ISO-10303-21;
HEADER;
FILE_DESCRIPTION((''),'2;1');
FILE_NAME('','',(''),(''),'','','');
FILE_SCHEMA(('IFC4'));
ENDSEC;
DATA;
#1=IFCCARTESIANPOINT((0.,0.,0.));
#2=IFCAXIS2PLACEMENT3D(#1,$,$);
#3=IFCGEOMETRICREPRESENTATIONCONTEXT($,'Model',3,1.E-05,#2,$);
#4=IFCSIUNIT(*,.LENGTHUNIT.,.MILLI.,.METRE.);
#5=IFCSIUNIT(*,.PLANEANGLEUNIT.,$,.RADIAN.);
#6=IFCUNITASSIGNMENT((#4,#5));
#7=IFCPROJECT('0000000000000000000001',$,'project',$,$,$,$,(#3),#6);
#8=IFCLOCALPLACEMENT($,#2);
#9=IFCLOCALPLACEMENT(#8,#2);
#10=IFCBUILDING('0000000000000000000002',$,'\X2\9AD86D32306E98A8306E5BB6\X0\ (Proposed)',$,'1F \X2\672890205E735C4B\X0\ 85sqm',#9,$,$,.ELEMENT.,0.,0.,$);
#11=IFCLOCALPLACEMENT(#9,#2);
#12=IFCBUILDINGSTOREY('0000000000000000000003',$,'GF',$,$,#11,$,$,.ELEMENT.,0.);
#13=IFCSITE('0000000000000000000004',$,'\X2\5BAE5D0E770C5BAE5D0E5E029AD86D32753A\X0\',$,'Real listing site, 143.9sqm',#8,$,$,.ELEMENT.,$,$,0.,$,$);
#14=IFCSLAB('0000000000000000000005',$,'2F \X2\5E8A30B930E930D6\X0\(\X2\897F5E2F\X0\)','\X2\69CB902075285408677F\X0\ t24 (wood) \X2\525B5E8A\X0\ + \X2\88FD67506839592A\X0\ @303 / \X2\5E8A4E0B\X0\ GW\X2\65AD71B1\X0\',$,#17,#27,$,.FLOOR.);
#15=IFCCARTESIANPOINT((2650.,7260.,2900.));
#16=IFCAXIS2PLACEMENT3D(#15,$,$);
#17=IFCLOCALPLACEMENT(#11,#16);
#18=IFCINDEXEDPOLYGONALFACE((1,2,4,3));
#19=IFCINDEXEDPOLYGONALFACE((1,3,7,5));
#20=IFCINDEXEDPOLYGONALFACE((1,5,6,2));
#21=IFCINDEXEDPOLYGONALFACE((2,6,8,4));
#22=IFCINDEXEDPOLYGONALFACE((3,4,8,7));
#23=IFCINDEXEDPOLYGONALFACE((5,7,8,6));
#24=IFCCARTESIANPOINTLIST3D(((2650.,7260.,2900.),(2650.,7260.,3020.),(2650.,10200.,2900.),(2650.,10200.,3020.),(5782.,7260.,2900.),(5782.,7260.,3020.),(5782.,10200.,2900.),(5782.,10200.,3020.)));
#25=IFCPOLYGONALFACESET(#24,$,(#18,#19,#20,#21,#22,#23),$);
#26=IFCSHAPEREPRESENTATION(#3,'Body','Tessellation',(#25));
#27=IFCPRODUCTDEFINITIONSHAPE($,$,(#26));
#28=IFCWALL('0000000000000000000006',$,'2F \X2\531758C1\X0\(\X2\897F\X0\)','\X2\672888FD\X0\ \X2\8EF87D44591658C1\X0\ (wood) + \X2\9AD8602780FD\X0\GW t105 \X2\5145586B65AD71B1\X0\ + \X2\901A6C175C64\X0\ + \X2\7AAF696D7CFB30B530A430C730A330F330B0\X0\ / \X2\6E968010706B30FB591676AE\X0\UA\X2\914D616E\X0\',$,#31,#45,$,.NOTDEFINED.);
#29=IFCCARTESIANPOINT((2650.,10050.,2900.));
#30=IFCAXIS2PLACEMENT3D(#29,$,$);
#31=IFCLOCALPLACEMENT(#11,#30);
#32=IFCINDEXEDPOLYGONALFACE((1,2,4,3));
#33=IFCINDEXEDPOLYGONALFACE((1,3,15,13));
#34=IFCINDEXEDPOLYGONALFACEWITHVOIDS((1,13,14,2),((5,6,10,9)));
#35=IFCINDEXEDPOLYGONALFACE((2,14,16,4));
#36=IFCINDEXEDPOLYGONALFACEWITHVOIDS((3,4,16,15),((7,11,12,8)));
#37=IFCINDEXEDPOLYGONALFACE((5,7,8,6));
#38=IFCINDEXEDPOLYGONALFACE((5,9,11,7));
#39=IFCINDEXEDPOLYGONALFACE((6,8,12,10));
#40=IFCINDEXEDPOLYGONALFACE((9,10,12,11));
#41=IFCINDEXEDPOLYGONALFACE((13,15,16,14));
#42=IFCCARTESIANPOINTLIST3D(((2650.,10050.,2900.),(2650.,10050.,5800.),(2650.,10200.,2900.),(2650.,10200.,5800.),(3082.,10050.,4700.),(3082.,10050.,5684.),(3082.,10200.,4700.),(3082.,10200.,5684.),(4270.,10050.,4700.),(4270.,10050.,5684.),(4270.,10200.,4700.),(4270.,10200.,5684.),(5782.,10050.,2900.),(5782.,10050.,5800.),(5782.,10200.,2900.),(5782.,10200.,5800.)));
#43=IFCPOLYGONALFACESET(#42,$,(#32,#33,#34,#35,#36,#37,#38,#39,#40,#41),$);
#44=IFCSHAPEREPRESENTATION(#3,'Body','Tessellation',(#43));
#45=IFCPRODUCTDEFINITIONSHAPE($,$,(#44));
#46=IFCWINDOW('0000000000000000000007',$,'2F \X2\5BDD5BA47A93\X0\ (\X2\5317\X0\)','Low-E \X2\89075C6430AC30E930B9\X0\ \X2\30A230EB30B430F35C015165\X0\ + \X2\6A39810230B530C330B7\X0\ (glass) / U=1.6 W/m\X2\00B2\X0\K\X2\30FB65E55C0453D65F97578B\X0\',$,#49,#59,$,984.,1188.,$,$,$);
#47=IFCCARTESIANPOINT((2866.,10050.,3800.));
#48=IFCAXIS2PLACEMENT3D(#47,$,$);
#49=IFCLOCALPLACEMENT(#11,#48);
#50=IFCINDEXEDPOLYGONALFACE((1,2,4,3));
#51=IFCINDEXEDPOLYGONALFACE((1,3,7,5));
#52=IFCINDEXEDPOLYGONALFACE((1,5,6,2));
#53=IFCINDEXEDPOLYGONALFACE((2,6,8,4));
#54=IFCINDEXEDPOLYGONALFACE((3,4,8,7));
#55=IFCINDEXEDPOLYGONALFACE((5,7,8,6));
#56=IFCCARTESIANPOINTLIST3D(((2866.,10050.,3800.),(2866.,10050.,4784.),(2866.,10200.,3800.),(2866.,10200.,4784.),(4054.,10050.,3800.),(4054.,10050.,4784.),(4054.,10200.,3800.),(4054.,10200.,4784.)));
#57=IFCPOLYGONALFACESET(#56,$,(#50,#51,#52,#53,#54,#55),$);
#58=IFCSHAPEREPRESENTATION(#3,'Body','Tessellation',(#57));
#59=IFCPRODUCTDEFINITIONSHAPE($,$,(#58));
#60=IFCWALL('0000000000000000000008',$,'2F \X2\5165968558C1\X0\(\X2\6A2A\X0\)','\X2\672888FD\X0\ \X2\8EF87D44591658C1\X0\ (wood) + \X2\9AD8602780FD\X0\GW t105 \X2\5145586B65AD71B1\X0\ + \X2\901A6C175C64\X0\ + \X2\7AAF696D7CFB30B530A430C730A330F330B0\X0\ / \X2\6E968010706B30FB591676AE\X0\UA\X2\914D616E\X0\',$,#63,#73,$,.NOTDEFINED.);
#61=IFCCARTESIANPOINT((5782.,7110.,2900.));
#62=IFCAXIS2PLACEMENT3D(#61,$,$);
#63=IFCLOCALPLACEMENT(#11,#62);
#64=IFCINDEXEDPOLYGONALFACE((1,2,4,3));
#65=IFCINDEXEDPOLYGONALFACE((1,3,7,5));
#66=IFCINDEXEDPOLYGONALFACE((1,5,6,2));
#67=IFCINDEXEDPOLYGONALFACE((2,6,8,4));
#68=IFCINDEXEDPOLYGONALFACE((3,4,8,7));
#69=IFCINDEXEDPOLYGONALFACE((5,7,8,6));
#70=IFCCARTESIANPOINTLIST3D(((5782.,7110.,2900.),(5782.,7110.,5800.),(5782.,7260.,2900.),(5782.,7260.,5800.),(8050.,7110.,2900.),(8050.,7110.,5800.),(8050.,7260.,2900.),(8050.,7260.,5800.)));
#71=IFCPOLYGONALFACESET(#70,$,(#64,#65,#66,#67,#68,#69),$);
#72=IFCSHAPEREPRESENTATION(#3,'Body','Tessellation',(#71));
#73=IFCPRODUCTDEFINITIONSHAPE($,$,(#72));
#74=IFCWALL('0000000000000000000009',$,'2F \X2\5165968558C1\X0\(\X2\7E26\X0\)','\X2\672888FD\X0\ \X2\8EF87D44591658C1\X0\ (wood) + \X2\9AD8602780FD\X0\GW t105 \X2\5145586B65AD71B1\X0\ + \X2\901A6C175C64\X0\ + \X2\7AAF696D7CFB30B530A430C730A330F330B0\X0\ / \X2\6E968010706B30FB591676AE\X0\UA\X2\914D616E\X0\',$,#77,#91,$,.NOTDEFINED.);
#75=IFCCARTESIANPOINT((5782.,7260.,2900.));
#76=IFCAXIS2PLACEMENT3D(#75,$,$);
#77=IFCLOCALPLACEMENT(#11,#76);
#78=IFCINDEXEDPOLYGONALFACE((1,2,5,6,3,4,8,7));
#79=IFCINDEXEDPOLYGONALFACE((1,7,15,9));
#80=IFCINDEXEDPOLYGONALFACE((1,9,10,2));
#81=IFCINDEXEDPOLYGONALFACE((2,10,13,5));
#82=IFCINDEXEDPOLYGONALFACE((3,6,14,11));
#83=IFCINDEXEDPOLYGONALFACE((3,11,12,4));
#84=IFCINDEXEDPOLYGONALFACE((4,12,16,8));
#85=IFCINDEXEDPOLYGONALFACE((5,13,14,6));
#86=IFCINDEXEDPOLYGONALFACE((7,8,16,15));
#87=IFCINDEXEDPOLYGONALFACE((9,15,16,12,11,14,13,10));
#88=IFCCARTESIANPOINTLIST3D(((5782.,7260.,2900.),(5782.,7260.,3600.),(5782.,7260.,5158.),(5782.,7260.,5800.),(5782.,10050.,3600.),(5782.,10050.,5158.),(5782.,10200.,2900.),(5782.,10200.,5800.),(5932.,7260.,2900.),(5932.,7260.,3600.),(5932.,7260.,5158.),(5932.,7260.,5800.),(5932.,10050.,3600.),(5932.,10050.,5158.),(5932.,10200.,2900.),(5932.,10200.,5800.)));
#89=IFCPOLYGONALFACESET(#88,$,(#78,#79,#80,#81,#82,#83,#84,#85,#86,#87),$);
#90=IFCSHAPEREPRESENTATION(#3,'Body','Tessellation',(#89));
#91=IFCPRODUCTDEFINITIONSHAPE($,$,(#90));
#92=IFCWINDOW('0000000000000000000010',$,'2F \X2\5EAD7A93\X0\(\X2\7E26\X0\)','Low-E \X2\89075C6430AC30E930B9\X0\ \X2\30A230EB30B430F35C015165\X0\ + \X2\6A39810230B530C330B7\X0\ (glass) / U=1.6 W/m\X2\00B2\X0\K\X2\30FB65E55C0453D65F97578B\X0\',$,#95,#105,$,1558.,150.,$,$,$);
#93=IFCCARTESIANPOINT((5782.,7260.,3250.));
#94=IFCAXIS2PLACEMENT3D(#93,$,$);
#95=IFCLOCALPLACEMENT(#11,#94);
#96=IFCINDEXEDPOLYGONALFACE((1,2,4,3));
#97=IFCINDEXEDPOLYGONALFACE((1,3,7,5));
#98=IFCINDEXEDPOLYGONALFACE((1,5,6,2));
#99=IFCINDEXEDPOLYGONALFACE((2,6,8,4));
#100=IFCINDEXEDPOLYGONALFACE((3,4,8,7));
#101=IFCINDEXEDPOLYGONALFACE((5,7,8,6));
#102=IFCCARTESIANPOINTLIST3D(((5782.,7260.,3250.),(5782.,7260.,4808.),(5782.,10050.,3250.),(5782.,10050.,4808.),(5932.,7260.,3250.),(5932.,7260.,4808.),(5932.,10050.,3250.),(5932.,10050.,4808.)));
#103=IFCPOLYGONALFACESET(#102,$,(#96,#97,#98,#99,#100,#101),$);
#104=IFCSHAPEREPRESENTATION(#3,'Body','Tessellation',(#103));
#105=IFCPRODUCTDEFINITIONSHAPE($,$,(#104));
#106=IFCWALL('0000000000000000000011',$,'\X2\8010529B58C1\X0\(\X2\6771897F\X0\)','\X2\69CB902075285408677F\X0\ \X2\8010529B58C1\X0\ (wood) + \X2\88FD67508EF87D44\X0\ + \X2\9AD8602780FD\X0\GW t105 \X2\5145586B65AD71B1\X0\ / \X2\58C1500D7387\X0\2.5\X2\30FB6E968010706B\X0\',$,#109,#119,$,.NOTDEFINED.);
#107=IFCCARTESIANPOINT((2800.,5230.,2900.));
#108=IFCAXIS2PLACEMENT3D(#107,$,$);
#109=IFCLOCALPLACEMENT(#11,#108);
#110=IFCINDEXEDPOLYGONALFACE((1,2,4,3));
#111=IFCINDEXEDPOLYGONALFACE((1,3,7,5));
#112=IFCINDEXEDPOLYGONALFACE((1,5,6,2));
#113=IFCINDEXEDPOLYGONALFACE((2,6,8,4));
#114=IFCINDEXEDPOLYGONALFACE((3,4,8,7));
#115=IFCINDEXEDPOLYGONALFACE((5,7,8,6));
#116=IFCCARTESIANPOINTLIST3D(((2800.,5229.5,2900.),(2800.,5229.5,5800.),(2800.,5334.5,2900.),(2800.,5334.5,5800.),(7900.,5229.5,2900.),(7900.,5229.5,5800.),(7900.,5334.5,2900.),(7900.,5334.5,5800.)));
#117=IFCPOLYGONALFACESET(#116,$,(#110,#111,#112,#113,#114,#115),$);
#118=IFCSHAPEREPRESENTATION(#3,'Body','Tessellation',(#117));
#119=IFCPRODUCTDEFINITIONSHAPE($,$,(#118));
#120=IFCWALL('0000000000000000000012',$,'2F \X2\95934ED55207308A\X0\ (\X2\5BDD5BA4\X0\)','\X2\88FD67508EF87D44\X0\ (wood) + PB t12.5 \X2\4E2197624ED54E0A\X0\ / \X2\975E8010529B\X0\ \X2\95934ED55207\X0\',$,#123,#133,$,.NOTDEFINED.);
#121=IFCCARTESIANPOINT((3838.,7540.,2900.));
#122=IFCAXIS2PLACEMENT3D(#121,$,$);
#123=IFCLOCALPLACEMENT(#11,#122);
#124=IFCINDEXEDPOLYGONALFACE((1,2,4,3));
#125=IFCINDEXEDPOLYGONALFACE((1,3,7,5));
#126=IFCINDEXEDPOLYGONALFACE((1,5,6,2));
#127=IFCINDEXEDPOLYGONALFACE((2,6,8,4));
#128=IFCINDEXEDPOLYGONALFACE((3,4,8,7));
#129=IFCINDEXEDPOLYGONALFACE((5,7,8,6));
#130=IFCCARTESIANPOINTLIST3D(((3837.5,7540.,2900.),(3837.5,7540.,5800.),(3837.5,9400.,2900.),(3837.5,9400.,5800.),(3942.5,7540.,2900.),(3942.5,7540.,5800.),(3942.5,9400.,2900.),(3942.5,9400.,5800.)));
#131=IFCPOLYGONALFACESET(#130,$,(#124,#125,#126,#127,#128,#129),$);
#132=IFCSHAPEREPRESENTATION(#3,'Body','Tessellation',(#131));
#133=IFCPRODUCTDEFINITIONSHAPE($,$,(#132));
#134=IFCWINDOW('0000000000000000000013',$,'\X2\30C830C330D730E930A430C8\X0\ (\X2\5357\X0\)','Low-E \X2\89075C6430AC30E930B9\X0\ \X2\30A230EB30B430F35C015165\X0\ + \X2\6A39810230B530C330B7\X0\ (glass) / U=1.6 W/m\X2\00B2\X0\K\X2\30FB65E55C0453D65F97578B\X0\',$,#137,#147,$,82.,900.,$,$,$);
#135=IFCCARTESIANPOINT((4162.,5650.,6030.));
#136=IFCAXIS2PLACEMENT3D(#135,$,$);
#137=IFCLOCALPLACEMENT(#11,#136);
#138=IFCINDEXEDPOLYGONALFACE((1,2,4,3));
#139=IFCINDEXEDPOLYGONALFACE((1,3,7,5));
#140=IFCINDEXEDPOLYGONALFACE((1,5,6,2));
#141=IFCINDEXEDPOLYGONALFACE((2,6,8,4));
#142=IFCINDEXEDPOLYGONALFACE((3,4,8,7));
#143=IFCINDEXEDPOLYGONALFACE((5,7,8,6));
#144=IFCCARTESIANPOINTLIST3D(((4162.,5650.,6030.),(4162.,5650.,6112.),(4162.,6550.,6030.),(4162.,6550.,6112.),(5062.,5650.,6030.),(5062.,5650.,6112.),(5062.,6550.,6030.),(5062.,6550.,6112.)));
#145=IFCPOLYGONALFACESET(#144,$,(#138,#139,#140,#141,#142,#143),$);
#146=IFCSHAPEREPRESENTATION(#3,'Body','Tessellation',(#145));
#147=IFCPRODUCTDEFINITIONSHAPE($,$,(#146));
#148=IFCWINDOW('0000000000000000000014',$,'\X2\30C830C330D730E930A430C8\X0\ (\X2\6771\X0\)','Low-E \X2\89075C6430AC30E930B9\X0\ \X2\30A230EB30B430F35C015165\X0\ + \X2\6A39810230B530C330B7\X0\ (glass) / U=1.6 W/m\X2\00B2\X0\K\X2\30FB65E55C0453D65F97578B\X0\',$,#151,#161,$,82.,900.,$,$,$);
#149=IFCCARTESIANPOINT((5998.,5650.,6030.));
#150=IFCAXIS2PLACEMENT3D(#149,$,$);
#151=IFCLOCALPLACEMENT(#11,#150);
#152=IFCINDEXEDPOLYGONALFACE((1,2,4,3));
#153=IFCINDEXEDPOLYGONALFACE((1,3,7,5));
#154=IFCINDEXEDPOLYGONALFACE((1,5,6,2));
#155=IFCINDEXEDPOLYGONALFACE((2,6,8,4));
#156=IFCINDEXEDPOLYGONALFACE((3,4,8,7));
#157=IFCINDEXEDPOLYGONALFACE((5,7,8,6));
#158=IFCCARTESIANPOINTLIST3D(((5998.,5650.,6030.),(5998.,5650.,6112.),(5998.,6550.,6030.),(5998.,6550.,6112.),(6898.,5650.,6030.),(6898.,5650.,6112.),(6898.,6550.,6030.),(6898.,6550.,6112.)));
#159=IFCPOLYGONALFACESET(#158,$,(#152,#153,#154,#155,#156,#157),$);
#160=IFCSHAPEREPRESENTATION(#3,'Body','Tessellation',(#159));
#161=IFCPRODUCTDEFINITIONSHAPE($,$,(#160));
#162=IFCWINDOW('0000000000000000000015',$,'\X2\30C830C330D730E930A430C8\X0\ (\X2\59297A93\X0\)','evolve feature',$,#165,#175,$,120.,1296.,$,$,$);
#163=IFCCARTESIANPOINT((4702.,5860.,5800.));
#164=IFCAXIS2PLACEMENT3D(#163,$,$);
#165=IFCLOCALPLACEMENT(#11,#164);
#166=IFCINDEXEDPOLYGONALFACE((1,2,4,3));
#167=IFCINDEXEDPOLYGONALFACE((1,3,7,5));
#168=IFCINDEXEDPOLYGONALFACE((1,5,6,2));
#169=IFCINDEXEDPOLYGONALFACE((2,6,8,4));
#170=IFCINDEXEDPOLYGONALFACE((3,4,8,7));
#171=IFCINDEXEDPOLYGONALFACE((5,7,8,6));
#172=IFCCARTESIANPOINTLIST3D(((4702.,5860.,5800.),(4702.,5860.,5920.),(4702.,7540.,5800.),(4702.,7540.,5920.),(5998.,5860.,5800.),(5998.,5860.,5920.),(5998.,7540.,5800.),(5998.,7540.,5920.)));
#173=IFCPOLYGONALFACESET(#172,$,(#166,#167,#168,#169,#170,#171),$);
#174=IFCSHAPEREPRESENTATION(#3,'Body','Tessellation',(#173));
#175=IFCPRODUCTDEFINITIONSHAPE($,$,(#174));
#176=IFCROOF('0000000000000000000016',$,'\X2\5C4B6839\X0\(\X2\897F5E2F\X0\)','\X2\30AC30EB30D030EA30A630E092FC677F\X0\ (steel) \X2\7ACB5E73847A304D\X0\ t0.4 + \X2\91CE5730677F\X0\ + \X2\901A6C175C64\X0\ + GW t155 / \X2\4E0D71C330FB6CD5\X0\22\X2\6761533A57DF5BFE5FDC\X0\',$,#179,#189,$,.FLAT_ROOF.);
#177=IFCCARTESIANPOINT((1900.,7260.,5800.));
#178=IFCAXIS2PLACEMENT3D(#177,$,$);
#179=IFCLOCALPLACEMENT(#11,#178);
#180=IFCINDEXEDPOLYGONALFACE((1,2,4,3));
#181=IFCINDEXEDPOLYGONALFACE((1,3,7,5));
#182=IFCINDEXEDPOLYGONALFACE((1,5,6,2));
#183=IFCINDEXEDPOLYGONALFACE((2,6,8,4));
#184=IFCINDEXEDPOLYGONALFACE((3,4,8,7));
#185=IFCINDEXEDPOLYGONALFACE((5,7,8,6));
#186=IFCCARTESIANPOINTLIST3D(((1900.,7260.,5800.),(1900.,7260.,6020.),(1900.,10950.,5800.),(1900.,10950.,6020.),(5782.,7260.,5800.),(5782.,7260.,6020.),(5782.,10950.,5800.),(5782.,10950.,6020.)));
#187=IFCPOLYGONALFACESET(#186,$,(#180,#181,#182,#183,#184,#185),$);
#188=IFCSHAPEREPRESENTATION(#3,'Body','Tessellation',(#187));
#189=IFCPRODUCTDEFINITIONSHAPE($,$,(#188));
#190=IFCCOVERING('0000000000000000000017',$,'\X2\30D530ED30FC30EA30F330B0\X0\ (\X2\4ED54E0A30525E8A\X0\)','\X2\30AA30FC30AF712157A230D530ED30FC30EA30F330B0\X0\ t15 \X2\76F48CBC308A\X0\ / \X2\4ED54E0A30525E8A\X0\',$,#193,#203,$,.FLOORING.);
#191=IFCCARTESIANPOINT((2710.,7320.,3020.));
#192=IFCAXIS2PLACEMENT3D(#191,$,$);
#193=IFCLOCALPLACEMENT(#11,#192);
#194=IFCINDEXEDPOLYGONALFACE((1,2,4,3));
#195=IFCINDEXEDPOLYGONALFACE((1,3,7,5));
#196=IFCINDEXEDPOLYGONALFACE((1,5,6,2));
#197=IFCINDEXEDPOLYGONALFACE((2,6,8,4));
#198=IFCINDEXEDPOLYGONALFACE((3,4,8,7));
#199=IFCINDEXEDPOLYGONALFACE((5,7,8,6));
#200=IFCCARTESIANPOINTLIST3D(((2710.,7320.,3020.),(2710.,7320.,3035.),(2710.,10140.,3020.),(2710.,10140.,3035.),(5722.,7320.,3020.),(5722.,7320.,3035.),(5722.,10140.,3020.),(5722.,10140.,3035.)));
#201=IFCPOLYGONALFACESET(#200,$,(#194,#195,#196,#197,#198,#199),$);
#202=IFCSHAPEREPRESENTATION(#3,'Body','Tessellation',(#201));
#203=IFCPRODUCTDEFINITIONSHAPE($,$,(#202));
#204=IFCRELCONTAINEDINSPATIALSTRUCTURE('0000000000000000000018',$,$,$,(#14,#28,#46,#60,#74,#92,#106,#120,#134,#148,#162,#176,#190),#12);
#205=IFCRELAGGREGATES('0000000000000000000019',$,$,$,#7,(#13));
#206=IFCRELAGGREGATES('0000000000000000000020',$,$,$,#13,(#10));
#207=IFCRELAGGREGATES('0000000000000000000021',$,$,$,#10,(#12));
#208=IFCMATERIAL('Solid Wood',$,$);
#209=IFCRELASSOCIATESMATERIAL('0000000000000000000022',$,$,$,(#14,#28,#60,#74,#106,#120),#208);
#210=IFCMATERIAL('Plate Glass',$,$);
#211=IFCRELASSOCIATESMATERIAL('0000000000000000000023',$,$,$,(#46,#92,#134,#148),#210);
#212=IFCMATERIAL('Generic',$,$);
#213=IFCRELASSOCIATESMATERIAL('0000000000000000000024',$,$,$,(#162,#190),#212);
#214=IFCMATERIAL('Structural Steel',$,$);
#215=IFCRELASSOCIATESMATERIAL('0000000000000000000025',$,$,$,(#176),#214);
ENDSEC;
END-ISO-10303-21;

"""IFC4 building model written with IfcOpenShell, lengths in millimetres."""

from ifc_helpers import new_model, si_unit, frame, frame_2d, origin, place, context, project, spatial, rectangle, extrude, material, element, fill, save


model = new_model("IFC4")

# Units and contexts
model_context = context("Model", 3, precision=1e-05, world=origin())
ifc_project = project(units=[si_unit("LENGTHUNIT", "METRE", prefix="MILLI"), si_unit("PLANEANGLEUNIT", "RADIAN")], contexts=[model_context])

# Site, building, storey
site_placement = place(None, origin())
site = spatial("IfcSite", under=ifc_project, at=site_placement, Name="宮崎県宮崎市高洲町", ObjectType="Real listing site, 143.9sqm", CompositionType="ELEMENT", RefElevation=0.0)
building_placement = place(site_placement, origin())
building = spatial("IfcBuilding", under=site, at=building_placement, Name="高洲の風の家 (Proposed)", ObjectType="1F 木造平屋 85sqm", CompositionType="ELEMENT", ElevationOfRefHeight=0.0, ElevationOfTerrain=0.0)
storey_placement = place(building_placement, origin())
storey = spatial("IfcBuildingStorey", under=building, at=storey_placement, Name="GF", CompositionType="ELEMENT", Elevation=0.0)

# Slab
ifc_material_1 = material(Name="Solid Wood")
slab_placement = place(storey_placement, frame((2650.0, 7260.0, 2900.0)))
element("IfcSlab", 1, at=slab_placement, inside=storey, material=ifc_material_1, Name="2F 床スラブ(西帯)", Description="構造用合板 t24 (wood) 剛床 + 製材根太 @303 / 床下 GW断熱", PredefinedType="FLOOR", context=model_context, shape_type="SweptSolid", body=[
    extrude(rectangle(XDim=3132.0, YDim=2940.0, at=frame_2d((1566.0, 1470.0))), frame((2650.0, 7260.0, 2900.0)), (0.0, 0.0, 1.0), 120.0),
])

# Wall, opening, window
wall_1_placement = place(storey_placement, frame((2650.0, 10050.0, 2900.0)))
wall_1 = element("IfcWall", 2, at=wall_1_placement, inside=storey, material=ifc_material_1, Name="2F 北壁(西)", Description="木製 軸組外壁 (wood) + 高性能GW t105 充填断熱 + 通気層 + 窯業系サイディング / 準耐火・外皮UA配慮", PredefinedType="NOTDEFINED", context=model_context, shape_type="SweptSolid", body=[
    extrude(rectangle(XDim=3132.0, YDim=150.0, at=frame_2d((1566.0, 75.0))), frame((2650.0, 10050.0, 2900.0)), (0.0, 0.0, 1.0), 2900.0),
])
opening_1_placement = place(storey_placement, frame((2866.0, 10050.0, 3800.0)))
opening_1 = element("IfcOpeningElement", 3, at=opening_1_placement, cuts=wall_1, PredefinedType="NOTDEFINED", context=model_context, shape_type="SweptSolid", body=[
    extrude(rectangle(XDim=1188.0, YDim=150.0, at=frame_2d((594.0, 75.0))), frame((2866.0, 10050.0, 3800.0)), (0.0, 0.0, 1.0), 984.0),
])
ifc_material_2 = material(Name="Plate Glass")
window_1_placement = place(storey_placement, frame((2866.0, 10050.0, 3800.0)))
window_1 = element("IfcWindow", 4, at=window_1_placement, inside=storey, material=ifc_material_2, Name="2F 寝室窓 (北)", Description="Low-E 複層ガラス アルゴン封入 + 樹脂サッシ (glass) / U=1.6 W/m²K・日射取得型", OverallHeight=984.0, OverallWidth=1188.0, context=model_context, shape_type="SweptSolid", body=[
    extrude(rectangle(XDim=1188.0, YDim=150.0, at=frame_2d((594.0, 75.0))), frame((2866.0, 10050.0, 3800.0)), (0.0, 0.0, 1.0), 984.0),
])
fill(opening_1, window_1)

# Wall
wall_2_placement = place(storey_placement, frame((5782.0, 7110.0, 2900.0)))
element("IfcWall", 5, at=wall_2_placement, inside=storey, material=ifc_material_1, Name="2F 入隅壁(横)", Description="木製 軸組外壁 (wood) + 高性能GW t105 充填断熱 + 通気層 + 窯業系サイディング / 準耐火・外皮UA配慮", PredefinedType="NOTDEFINED", context=model_context, shape_type="SweptSolid", body=[
    extrude(rectangle(XDim=2268.0, YDim=150.0, at=frame_2d((1134.0, 75.0))), frame((5782.0, 7110.0, 2900.0)), (0.0, 0.0, 1.0), 2900.0),
])

# Wall, opening, window
wall_3_placement = place(storey_placement, frame((5782.0, 7260.0, 2900.0)))
wall_3 = element("IfcWall", 6, at=wall_3_placement, inside=storey, material=ifc_material_1, Name="2F 入隅壁(縦)", Description="木製 軸組外壁 (wood) + 高性能GW t105 充填断熱 + 通気層 + 窯業系サイディング / 準耐火・外皮UA配慮", PredefinedType="NOTDEFINED", context=model_context, shape_type="SweptSolid", body=[
    extrude(rectangle(XDim=150.0, YDim=2940.0, at=frame_2d((75.0, 1470.0))), frame((5782.0, 7260.0, 2900.0)), (0.0, 0.0, 1.0), 2900.0),
])
opening_2_placement = place(storey_placement, frame((5782.0, 7260.0, 3250.0)))
opening_2 = element("IfcOpeningElement", 7, at=opening_2_placement, cuts=wall_3, PredefinedType="NOTDEFINED", context=model_context, shape_type="SweptSolid", body=[
    extrude(rectangle(XDim=150.0, YDim=2790.0, at=frame_2d((75.0, 1395.0))), frame((5782.0, 7260.0, 3250.0)), (0.0, 0.0, 1.0), 1558.0),
])
window_2_placement = place(storey_placement, frame((5782.0, 7260.0, 3250.0)))
window_2 = element("IfcWindow", 8, at=window_2_placement, inside=storey, material=ifc_material_2, Name="2F 庭窓(縦)", Description="Low-E 複層ガラス アルゴン封入 + 樹脂サッシ (glass) / U=1.6 W/m²K・日射取得型", OverallHeight=1558.0, OverallWidth=150.0, context=model_context, shape_type="SweptSolid", body=[
    extrude(rectangle(XDim=150.0, YDim=2790.0, at=frame_2d((75.0, 1395.0))), frame((5782.0, 7260.0, 3250.0)), (0.0, 0.0, 1.0), 1558.0),
])
fill(opening_2, window_2)

# Walls
wall_4_placement = place(storey_placement, frame((2800.0, 5230.0, 2900.0)))
element("IfcWall", 9, at=wall_4_placement, inside=storey, material=ifc_material_1, Name="耐力壁(東西)", Description="構造用合板 耐力壁 (wood) + 製材軸組 + 高性能GW t105 充填断熱 / 壁倍率2.5・準耐火", PredefinedType="NOTDEFINED", context=model_context, shape_type="SweptSolid", body=[
    extrude(rectangle(XDim=5100.0, YDim=105.0, at=frame_2d((2550.0, 52.0))), frame((2800.0, 5230.0, 2900.0)), (0.0, 0.0, 1.0), 2900.0),
])
wall_5_placement = place(storey_placement, frame((3838.0, 7540.0, 2900.0)))
element("IfcWall", 10, at=wall_5_placement, inside=storey, material=ifc_material_1, Name="2F 間仕切り (寝室)", Description="製材軸組 (wood) + PB t12.5 両面仕上 / 非耐力 間仕切", PredefinedType="NOTDEFINED", context=model_context, shape_type="SweptSolid", body=[
    extrude(rectangle(XDim=105.0, YDim=1860.0, at=frame_2d((52.0, 930.0))), frame((3838.0, 7540.0, 2900.0)), (0.0, 0.0, 1.0), 2900.0),
])

# Windows
window_3_placement = place(storey_placement, frame((4162.0, 5650.0, 6030.0)))
element("IfcWindow", 11, at=window_3_placement, inside=storey, material=ifc_material_2, Name="トップライト (南)", Description="Low-E 複層ガラス アルゴン封入 + 樹脂サッシ (glass) / U=1.6 W/m²K・日射取得型", OverallHeight=82.0, OverallWidth=900.0, context=model_context, shape_type="SweptSolid", body=[
    extrude(rectangle(XDim=900.0, YDim=900.0, at=frame_2d((450.0, 450.0))), frame((4162.0, 5650.0, 6030.0)), (0.0, 0.0, 1.0), 82.0),
])
window_4_placement = place(storey_placement, frame((5998.0, 5650.0, 6030.0)))
element("IfcWindow", 12, at=window_4_placement, inside=storey, material=ifc_material_2, Name="トップライト (東)", Description="Low-E 複層ガラス アルゴン封入 + 樹脂サッシ (glass) / U=1.6 W/m²K・日射取得型", OverallHeight=82.0, OverallWidth=900.0, context=model_context, shape_type="SweptSolid", body=[
    extrude(rectangle(XDim=900.0, YDim=900.0, at=frame_2d((450.0, 450.0))), frame((5998.0, 5650.0, 6030.0)), (0.0, 0.0, 1.0), 82.0),
])
ifc_material_3 = material(Name="Generic")
window_5_placement = place(storey_placement, frame((4702.0, 5860.0, 5800.0)))
element("IfcWindow", 13, at=window_5_placement, inside=storey, material=ifc_material_3, Name="トップライト (天窓)", Description="evolve feature", OverallHeight=120.0, OverallWidth=1296.0, context=model_context, shape_type="SweptSolid", body=[
    extrude(rectangle(XDim=1296.0, YDim=1680.0, at=frame_2d((648.0, 840.0))), frame((4702.0, 5860.0, 5800.0)), (0.0, 0.0, 1.0), 120.0),
])

# Roof
ifc_material_4 = material(Name="Structural Steel")
for number, where, name in (
    (14, (1900.0, 7260.0, 5800.0), "屋根(西帯)"),
):
    element("IfcRoof", number, at=place(storey_placement, frame(where)), inside=storey, material=ifc_material_4, Name=name, Description="ガルバリウム鋼板 (steel) 立平葺き t0.4 + 野地板 + 通気層 + GW t155 / 不燃・法22条区域対応", PredefinedType="FLAT_ROOF", context=model_context, shape_type="SweptSolid", body=[
        extrude(rectangle(XDim=3882.0, YDim=3690.0, at=frame_2d((1941.0, 1845.0))), frame((1900.0, 7260.0, 5800.0)), (0.0, 0.0, 1.0), 220.0),
    ])

# Covering
covering_placement = place(storey_placement, frame((2710.0, 7320.0, 3020.0)))
element("IfcCovering", 15, at=covering_placement, inside=storey, material=ifc_material_3, Name="フローリング (仕上げ床)", Description="オーク無垢フローリング t15 直貼り / 仕上げ床", PredefinedType="FLOORING", context=model_context, shape_type="SweptSolid", body=[
    extrude(rectangle(XDim=3012.0, YDim=2820.0, at=frame_2d((1506.0, 1410.0))), frame((2710.0, 7320.0, 3020.0)), (0.0, 0.0, 1.0), 15.0),
])

save(model, "model.ifc")
